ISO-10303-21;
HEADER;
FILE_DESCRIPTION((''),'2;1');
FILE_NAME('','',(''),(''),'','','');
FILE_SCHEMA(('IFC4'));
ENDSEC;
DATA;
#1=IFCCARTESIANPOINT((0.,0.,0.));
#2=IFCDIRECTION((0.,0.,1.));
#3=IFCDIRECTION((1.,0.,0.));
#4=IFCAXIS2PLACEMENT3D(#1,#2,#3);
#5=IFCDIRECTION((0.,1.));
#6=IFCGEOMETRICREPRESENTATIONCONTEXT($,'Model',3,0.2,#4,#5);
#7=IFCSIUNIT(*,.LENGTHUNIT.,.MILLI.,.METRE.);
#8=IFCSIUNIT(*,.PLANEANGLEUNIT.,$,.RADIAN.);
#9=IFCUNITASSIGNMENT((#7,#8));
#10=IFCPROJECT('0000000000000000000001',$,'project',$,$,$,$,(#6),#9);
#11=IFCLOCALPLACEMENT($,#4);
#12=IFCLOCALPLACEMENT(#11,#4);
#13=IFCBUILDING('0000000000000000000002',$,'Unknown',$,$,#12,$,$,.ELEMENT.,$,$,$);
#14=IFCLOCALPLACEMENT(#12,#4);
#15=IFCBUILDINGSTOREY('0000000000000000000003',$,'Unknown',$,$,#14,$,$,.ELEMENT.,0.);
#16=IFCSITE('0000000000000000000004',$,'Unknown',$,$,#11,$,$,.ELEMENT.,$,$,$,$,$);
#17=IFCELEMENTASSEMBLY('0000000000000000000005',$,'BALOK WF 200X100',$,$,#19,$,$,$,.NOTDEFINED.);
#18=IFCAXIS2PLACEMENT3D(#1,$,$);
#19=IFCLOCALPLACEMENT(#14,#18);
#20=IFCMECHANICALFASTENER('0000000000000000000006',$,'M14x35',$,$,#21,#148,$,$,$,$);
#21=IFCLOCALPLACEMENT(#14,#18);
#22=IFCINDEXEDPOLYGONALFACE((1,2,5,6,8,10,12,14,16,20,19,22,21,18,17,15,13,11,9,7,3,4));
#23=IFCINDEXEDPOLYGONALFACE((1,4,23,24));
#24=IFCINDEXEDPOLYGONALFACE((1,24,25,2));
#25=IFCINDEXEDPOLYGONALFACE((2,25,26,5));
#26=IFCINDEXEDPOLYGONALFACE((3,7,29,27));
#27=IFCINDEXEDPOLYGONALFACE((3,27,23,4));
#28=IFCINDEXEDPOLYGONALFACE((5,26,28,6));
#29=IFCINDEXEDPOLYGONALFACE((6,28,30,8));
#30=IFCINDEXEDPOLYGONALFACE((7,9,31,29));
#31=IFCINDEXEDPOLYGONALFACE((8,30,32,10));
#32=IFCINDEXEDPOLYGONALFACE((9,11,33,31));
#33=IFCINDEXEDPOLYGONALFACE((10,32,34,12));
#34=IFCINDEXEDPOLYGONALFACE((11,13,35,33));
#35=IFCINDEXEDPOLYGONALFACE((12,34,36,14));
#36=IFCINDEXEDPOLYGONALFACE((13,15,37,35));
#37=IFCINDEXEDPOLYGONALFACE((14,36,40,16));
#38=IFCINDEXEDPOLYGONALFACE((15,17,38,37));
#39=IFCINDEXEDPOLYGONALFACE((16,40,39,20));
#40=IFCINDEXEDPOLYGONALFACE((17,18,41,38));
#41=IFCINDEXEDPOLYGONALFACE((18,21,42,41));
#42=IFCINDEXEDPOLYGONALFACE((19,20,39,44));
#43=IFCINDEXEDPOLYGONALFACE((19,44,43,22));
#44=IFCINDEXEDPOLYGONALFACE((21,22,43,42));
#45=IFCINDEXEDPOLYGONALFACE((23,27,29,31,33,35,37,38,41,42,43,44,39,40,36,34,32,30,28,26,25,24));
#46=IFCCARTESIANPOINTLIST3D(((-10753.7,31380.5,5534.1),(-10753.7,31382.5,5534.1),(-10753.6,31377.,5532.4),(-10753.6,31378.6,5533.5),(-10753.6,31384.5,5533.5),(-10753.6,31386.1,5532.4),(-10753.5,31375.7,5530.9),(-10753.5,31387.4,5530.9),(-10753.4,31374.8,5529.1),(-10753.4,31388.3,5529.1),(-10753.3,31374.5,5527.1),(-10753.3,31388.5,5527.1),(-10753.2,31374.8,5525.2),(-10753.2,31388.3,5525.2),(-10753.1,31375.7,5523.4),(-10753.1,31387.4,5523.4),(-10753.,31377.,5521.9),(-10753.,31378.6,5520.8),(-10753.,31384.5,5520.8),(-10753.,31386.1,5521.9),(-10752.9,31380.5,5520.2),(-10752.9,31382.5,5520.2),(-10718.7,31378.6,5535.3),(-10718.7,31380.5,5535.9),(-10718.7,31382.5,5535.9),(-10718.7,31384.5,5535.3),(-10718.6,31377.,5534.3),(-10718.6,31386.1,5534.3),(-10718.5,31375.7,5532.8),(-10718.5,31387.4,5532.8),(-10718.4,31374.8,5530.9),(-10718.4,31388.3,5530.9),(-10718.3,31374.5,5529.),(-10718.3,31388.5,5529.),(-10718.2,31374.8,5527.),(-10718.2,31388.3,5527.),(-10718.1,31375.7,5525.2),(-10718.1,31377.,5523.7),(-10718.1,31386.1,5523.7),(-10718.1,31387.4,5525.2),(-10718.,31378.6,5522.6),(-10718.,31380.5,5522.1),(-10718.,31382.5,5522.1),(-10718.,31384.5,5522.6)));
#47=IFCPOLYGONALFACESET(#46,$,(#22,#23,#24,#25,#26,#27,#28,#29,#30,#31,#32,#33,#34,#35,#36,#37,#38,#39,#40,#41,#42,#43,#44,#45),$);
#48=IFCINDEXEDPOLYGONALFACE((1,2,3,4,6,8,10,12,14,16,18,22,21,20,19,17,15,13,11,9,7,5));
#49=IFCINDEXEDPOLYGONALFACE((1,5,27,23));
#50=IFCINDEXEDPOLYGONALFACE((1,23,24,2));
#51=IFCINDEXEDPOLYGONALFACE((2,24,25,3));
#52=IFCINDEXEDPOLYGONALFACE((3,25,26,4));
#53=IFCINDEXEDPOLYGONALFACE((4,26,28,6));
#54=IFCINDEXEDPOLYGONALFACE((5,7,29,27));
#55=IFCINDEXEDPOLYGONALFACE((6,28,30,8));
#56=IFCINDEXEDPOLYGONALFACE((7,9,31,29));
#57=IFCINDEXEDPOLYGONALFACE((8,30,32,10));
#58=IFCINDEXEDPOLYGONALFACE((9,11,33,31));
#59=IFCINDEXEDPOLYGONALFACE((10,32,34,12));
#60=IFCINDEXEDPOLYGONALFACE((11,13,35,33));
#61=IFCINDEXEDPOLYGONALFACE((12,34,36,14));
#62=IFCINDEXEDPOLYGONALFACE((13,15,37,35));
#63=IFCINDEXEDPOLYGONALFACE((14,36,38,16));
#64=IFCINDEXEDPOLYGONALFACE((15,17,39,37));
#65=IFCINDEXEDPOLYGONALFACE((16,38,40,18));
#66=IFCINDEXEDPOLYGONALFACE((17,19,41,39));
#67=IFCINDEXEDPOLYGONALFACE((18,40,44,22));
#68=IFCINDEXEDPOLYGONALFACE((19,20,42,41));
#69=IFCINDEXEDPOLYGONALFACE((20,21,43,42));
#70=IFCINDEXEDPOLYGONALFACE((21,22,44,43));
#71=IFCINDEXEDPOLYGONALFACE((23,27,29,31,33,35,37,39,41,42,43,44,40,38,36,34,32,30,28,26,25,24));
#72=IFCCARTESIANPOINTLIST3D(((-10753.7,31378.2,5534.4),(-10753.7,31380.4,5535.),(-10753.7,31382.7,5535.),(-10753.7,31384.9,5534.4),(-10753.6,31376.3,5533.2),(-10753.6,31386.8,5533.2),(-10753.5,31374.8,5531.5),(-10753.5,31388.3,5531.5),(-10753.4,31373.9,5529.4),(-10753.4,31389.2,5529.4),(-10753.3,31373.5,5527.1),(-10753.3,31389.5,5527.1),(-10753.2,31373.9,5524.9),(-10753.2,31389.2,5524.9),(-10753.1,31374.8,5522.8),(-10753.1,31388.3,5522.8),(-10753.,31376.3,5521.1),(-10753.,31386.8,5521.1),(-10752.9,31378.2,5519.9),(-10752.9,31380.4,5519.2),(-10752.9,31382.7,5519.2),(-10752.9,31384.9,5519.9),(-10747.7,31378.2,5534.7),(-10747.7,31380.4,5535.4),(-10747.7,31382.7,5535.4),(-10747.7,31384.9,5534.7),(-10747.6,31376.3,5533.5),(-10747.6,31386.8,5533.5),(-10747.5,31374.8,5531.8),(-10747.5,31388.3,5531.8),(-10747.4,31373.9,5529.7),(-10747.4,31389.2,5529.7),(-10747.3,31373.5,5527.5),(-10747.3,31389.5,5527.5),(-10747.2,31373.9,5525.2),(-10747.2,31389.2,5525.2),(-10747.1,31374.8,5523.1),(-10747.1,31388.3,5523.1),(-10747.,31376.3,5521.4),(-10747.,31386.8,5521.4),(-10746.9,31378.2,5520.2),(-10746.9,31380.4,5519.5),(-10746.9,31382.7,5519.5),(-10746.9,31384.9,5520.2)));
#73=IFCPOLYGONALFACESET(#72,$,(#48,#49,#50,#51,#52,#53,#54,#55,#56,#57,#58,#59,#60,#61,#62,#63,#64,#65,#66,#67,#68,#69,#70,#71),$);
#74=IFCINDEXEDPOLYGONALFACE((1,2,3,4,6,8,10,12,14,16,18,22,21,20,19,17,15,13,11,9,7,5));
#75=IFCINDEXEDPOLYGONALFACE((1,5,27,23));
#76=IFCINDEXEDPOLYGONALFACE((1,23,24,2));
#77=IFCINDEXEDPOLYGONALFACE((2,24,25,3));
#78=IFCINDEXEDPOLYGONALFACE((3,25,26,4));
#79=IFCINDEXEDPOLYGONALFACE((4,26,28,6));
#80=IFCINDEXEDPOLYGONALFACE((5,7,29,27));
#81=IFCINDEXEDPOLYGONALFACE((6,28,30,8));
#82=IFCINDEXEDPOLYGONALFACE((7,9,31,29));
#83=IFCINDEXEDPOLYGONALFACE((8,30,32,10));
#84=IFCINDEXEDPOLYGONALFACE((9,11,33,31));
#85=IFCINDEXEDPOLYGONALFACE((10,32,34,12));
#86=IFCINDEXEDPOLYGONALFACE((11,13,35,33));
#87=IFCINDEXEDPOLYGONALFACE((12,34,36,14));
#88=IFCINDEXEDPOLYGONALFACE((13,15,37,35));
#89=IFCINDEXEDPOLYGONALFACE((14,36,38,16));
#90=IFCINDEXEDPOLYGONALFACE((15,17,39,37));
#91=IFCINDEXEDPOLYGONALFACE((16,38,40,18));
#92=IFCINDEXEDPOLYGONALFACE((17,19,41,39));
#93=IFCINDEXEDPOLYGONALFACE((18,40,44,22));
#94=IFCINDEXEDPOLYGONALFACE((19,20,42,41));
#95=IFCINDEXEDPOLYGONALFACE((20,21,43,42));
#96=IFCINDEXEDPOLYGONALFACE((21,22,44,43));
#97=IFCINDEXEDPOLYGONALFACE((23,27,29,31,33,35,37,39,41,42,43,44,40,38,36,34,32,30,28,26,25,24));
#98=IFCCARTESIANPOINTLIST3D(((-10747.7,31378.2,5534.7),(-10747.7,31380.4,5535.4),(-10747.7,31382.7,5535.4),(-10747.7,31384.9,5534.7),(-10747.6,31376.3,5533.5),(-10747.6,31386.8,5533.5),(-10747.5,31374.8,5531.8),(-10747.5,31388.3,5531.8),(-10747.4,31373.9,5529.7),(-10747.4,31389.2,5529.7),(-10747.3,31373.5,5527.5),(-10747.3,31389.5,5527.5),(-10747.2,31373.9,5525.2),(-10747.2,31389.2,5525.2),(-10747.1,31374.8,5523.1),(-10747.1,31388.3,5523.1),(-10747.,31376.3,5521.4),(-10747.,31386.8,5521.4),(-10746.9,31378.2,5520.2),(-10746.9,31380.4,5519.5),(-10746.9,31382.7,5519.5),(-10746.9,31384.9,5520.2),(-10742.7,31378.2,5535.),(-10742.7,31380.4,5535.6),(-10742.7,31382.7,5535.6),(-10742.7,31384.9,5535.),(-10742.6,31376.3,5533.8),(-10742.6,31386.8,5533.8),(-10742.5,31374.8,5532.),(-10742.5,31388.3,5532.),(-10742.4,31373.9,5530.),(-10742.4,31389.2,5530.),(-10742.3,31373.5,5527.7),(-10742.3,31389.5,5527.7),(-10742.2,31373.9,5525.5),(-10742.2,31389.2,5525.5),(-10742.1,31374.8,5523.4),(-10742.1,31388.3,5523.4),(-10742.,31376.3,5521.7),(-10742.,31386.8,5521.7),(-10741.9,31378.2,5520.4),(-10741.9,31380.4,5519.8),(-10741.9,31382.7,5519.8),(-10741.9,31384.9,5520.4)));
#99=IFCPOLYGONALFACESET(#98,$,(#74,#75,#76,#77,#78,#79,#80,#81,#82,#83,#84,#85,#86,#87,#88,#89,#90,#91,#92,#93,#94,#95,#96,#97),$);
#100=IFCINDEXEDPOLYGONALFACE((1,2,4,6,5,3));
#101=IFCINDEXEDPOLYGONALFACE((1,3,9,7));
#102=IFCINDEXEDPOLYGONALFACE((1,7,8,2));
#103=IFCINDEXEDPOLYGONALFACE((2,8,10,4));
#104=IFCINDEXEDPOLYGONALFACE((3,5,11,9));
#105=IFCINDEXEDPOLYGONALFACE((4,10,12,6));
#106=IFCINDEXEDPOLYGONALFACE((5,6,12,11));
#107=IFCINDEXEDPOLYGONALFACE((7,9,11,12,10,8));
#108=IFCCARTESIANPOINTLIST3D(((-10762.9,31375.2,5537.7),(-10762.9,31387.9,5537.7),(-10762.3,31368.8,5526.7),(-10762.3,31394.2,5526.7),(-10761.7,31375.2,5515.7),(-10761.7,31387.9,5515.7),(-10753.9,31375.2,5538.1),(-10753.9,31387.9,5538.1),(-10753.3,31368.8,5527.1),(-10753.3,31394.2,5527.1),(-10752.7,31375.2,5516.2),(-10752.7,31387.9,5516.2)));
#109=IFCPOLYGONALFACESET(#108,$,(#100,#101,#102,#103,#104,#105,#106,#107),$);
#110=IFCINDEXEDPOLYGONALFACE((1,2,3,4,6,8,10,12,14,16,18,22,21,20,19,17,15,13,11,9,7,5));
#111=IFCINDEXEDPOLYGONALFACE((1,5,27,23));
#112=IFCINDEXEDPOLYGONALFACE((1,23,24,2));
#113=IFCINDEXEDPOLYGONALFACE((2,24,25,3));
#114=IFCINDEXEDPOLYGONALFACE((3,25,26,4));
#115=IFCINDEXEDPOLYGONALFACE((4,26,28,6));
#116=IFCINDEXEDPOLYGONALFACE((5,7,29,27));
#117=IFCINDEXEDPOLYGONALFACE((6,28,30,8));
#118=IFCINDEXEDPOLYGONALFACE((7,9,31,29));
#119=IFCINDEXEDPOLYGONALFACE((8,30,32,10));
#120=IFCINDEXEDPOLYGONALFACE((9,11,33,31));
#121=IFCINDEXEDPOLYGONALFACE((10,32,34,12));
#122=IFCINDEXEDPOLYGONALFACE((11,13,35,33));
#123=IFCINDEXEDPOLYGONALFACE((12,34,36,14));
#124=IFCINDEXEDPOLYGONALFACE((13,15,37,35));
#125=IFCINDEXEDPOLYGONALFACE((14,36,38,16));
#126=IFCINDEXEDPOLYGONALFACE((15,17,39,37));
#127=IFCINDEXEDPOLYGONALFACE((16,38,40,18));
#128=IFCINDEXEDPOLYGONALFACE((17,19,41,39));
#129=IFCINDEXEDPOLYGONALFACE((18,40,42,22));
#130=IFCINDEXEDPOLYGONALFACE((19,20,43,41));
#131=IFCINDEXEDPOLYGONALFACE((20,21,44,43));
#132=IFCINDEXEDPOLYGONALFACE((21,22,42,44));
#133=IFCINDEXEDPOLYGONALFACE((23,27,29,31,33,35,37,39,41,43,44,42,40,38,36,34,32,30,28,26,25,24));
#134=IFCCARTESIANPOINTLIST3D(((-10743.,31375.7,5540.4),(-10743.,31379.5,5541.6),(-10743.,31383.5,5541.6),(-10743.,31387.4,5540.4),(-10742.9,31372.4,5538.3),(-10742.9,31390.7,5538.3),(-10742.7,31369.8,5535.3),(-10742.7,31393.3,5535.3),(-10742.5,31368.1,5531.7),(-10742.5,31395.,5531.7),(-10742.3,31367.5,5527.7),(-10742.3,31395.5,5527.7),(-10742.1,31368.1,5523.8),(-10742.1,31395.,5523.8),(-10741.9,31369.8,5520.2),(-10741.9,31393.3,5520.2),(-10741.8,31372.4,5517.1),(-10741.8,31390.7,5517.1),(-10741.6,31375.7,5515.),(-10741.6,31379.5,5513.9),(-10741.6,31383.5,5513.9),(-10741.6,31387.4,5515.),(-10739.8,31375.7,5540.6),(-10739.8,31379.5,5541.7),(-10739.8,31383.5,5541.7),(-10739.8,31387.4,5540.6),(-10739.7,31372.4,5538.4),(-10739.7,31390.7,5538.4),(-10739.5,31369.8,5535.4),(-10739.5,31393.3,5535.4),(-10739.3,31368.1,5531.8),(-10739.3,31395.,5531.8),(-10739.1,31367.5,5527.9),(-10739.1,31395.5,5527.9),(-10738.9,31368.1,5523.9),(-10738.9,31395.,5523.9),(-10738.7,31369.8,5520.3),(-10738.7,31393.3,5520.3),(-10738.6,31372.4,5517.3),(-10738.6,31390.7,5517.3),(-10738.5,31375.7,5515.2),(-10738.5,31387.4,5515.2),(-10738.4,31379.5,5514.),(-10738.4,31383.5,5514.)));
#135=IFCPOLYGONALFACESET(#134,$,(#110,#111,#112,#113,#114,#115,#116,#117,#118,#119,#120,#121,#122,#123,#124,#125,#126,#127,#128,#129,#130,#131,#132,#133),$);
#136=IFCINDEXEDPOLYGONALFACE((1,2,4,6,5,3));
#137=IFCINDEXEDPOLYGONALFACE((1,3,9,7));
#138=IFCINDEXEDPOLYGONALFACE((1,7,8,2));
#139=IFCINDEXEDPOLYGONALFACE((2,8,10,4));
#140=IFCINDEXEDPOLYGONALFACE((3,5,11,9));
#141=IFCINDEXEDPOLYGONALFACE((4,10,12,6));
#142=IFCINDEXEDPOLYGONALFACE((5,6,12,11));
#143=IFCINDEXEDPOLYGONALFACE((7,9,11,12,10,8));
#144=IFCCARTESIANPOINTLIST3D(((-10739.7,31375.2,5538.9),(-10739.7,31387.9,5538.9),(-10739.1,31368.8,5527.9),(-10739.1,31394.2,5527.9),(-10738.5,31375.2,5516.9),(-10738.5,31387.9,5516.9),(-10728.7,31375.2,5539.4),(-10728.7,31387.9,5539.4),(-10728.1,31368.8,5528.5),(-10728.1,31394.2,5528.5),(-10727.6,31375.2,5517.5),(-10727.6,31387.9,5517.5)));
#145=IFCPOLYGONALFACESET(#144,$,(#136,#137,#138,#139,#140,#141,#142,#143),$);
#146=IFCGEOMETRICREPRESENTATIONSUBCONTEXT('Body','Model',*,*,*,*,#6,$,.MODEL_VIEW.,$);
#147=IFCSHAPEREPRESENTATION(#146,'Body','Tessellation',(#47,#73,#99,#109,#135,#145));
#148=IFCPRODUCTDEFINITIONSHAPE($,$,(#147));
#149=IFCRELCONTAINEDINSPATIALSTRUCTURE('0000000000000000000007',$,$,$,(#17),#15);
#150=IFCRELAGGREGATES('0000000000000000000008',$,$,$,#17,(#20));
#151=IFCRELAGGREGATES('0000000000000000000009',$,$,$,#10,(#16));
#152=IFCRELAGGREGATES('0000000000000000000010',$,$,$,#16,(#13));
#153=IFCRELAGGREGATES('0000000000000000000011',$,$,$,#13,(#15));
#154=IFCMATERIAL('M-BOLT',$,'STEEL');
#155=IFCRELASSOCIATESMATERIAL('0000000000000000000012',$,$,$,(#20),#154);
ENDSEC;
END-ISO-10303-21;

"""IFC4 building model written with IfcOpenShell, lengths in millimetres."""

from ifc_helpers import new_model, si_unit, direction, frame, origin_with_axes, place, context, subcontext, project, spatial, line, arc, indexed_curve, outline, extrude, source, transform, mapped, material, element, aggregate, save


model = new_model("IFC4")

# Units and contexts
model_context = context("Model", 3, precision=0.2, world=origin_with_axes(), true_north=direction((0.0, 1.0)))
body_context = subcontext(model_context, "Body", "Model", "MODEL_VIEW")
ifc_project = project(units=[si_unit("LENGTHUNIT", "METRE", prefix="MILLI"), si_unit("PLANEANGLEUNIT", "RADIAN")], contexts=[model_context])

# Site, building, storey
site_placement = place(None, origin_with_axes())
site = spatial("IfcSite", under=ifc_project, at=site_placement, Name="Unknown", CompositionType="ELEMENT")
building_placement = place(site_placement, origin_with_axes())
building = spatial("IfcBuilding", under=site, at=building_placement, Name="Unknown", CompositionType="ELEMENT")
storey_placement = place(building_placement, origin_with_axes())
storey = spatial("IfcBuildingStorey", under=building, at=storey_placement, Name="Unknown", CompositionType="ELEMENT", Elevation=0.0)

# Element assembly
assembly_1_placement = place(storey_placement, frame((-7044.1, 31466.5, 5721.5), z_axis=(0.0, 1.0, 0.0), x_axis=(-0.99863, 0.0, -0.052336)))
assembly_1 = element("IfcElementAssembly", 1, at=assembly_1_placement, inside=storey, Name="BALOK WF 200X100", PredefinedType="NOTDEFINED")

# Shared definitions
ifc_material_1 = material(Name="M-BOLT", Category="STEEL")

# Mechanical fastener
shared_shape_1 = source(origin_with_axes(), body_context, "Body", "SweptSolid", [
    extrude(outline(indexed_curve([(7.0, 0.0), (0.0, 7.0), (-7.0, 0.0), (0.0, -7.0)], segments=[arc(1, 2, 3), arc(3, 4, 1)])), frame((0.0, 0.0, -2.6), z_axis=(0.0, 0.0, -1.0), x_axis=(0.0, 1.0, 0.0)), (0.0, 0.0, 1.0), 35.0),
    extrude(outline(indexed_curve([(8.0, 0.0), (0.0, 8.0), (-8.0, 0.0), (0.0, -8.0)], segments=[arc(1, 2, 3), arc(3, 4, 1)])), frame((0.0, 0.0, -2.6), z_axis=(0.0, 0.0, -1.0), x_axis=(0.0, 1.0, 0.0)), (0.0, 0.0, 1.0), 6.0),
    extrude(outline(indexed_curve([(8.0, 0.0), (0.0, 8.0), (-8.0, 0.0), (0.0, -8.0)], segments=[arc(1, 2, 3), arc(3, 4, 1)])), frame((0.0, 0.0, -8.6), z_axis=(0.0, 0.0, -1.0), x_axis=(0.0, 1.0, 0.0)), (0.0, 0.0, 1.0), 5.0),
    extrude(outline(indexed_curve([(12.7, 0.0), (6.4, 11.0), (-6.4, 11.0), (-12.7, 0.0), (-6.4, -11.0), (6.4, -11.0)], segments=[line(1, 2, 3, 4, 5, 6, 1)])), frame((0.0, 0.0, 6.4), z_axis=(0.0, 0.0, -1.0), x_axis=(0.0, 1.0, 0.0)), (0.0, 0.0, 1.0), 9.0),
    extrude(outline(indexed_curve([(14.0, 0.0), (0.0, 14.0), (-14.0, 0.0), (0.0, -14.0)], segments=[arc(1, 2, 3), arc(3, 4, 1)])), frame((0.0, 0.0, -13.6), z_axis=(0.0, 0.0, -1.0), x_axis=(0.0, 1.0, 0.0)), (0.0, 0.0, 1.0), 3.2),
    extrude(outline(indexed_curve([(12.7, 0.0), (6.4, 11.0), (-6.4, 11.0), (-12.7, 0.0), (-6.4, -11.0), (6.4, -11.0)], segments=[line(1, 2, 3, 4, 5, 6, 1)])), frame((0.0, 0.0, -16.8), z_axis=(0.0, 0.0, -1.0), x_axis=(0.0, 1.0, 0.0)), (0.0, 0.0, 1.0), 11.0),
])
mechanical_fastener_1_placement = place(assembly_1_placement, frame((3716.9, 0.1, -85.0), z_axis=(1.0, 0.0, -0.000006), x_axis=(0.0, -1.0, 0.0)))
mechanical_fastener_1 = element("IfcMechanicalFastener", 2, at=mechanical_fastener_1_placement, material=ifc_material_1, Name="M14x35", context=body_context, shape_type="MappedRepresentation", body=[
    mapped(shared_shape_1, transform((0.0, 0.0, 0.0))),
])
aggregate(assembly_1, [mechanical_fastener_1])

save(model, "model.ifc")
